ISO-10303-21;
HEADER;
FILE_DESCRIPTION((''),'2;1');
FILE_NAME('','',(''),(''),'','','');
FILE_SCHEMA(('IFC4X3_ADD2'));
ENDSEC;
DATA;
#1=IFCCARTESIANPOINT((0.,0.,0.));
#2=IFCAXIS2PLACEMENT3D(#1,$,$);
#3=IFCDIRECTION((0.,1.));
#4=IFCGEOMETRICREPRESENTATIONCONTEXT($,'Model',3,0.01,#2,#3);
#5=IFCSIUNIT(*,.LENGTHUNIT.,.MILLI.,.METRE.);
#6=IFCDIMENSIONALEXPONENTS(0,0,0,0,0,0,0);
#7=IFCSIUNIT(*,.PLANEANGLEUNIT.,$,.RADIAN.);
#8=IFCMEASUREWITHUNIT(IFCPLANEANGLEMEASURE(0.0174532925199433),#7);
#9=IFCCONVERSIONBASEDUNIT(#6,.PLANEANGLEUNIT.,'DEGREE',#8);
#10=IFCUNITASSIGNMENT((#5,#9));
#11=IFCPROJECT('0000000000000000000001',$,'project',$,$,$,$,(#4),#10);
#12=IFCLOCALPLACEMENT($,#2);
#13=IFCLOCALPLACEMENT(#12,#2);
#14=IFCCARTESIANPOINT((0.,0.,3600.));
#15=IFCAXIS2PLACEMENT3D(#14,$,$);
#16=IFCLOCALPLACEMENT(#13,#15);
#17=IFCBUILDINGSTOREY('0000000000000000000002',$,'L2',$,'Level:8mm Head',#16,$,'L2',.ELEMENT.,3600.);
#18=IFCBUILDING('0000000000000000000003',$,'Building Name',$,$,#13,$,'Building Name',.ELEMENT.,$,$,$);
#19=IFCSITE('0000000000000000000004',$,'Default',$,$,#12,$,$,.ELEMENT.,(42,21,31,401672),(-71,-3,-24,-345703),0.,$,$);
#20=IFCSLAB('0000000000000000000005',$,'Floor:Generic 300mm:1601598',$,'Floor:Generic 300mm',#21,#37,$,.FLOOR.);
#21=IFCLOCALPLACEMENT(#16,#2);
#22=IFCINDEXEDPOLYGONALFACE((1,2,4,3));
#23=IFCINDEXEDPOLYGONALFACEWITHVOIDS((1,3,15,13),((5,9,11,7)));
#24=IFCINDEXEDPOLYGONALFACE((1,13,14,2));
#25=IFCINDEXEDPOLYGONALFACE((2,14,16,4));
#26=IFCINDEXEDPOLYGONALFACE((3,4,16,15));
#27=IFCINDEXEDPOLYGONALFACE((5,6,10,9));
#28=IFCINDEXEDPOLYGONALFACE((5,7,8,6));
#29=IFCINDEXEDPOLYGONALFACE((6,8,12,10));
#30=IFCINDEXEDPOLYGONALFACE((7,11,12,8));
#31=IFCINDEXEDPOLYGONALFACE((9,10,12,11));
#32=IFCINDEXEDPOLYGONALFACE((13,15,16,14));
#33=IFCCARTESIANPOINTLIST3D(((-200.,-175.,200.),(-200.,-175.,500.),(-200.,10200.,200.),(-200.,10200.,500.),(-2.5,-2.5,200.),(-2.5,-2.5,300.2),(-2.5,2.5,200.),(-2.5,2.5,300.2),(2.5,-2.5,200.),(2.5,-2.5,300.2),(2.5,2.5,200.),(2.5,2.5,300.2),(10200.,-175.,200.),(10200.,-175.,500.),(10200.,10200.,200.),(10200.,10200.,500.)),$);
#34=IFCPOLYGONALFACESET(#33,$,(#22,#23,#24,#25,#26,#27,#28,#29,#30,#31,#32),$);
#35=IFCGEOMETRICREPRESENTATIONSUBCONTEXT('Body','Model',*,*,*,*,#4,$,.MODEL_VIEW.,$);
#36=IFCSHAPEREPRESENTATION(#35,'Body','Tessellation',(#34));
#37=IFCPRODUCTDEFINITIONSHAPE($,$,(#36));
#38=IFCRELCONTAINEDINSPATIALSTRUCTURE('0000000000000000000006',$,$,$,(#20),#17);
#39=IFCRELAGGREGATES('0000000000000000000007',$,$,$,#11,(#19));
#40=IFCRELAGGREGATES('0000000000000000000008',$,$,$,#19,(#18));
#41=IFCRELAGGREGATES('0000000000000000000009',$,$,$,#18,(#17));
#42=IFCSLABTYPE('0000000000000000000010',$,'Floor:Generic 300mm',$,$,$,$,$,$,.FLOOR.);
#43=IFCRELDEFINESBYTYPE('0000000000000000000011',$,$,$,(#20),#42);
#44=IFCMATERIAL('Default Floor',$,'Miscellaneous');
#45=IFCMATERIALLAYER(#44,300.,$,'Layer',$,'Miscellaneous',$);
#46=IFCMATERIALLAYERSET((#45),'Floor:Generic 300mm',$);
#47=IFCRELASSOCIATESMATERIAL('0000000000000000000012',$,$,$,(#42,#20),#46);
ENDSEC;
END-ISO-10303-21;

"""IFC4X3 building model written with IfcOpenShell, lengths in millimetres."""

from ifc_helpers import new_model, entity, si_unit, converted_unit, direction, frame, frame_2d, origin, origin_2d, place, context, subcontext, project, spatial, rectangle, extrude, material, layer, layer_set, layer_usage, type_object, element, save


model = new_model("IFC4X3")

# Units and contexts
model_context = context("Model", 3, precision=0.01, world=origin(), true_north=direction((0.0, 1.0)))
body_context = subcontext(model_context, "Body", "Model", "MODEL_VIEW")
ifc_project = project(units=[si_unit("LENGTHUNIT", "METRE", prefix="MILLI"), converted_unit("PLANEANGLEUNIT", "DEGREE", entity("IfcPlaneAngleMeasure", 0.0174532925199433), si_unit("PLANEANGLEUNIT", "RADIAN"), dimensions=[0, 0, 0, 0, 0, 0, 0])], contexts=[model_context])

# Site, building, storey
site_placement = place(None, origin())
site = spatial("IfcSite", under=ifc_project, at=site_placement, Name="Default", CompositionType="ELEMENT", RefLatitude=(42, 21, 31, 401672), RefLongitude=(-71, -3, -24, -345703), RefElevation=0.0)
building_placement = place(site_placement, origin())
building = spatial("IfcBuilding", under=site, at=building_placement, Name="Building Name", LongName="Building Name", CompositionType="ELEMENT")
storey_placement = place(building_placement, frame((0.0, 0.0, 3600.0)))
storey = spatial("IfcBuildingStorey", under=building, at=storey_placement, Name="L2", ObjectType="Level:8mm Head", LongName="L2", CompositionType="ELEMENT", Elevation=3600.0)

# Slab, opening
ifc_material = material(Name="Default Floor", Category="Miscellaneous")
ifc_layer = layer(ifc_material, 300.0, Name="Layer", Category="Miscellaneous")
ifc_layer_set = layer_set([ifc_layer], Name="Floor:Generic 300mm")
ifc_layer_usage = layer_usage(ifc_layer_set, "AXIS3", "POSITIVE", 0.0)
slab_type = type_object("IfcSlabType", Name="Floor:Generic 300mm", PredefinedType="FLOOR", material=ifc_layer_set)
placement = place(storey_placement, origin())
slab = element("IfcSlab", 1, at=placement, inside=storey, type_object=slab_type, material=ifc_layer_usage, Name="Floor:Generic 300mm:1601598", ObjectType="Floor:Generic 300mm", PredefinedType="FLOOR", context=body_context, shape_type="SweptSolid", body=[
    extrude(rectangle(XDim=10375.0, YDim=10400.0, at=frame_2d((0.0, 0.0), x_axis=(1.0, 0.0))), frame((5000.0, 5012.5, 500.0), z_axis=(0.0, 0.0, -1.0), x_axis=(0.0, 1.0, 0.0)), (0.0, 0.0, 1.0), 300.0),
])
element("IfcOpeningElement", 2, at=placement, cuts=slab, context=model_context, shape_type="SweptSolid", body=[
    extrude(rectangle(XDim=5.0, YDim=5.0, at=origin_2d()), origin(), (0.0, 0.0, 1.0), 300.2),
])

save(model, "model.ifc")
